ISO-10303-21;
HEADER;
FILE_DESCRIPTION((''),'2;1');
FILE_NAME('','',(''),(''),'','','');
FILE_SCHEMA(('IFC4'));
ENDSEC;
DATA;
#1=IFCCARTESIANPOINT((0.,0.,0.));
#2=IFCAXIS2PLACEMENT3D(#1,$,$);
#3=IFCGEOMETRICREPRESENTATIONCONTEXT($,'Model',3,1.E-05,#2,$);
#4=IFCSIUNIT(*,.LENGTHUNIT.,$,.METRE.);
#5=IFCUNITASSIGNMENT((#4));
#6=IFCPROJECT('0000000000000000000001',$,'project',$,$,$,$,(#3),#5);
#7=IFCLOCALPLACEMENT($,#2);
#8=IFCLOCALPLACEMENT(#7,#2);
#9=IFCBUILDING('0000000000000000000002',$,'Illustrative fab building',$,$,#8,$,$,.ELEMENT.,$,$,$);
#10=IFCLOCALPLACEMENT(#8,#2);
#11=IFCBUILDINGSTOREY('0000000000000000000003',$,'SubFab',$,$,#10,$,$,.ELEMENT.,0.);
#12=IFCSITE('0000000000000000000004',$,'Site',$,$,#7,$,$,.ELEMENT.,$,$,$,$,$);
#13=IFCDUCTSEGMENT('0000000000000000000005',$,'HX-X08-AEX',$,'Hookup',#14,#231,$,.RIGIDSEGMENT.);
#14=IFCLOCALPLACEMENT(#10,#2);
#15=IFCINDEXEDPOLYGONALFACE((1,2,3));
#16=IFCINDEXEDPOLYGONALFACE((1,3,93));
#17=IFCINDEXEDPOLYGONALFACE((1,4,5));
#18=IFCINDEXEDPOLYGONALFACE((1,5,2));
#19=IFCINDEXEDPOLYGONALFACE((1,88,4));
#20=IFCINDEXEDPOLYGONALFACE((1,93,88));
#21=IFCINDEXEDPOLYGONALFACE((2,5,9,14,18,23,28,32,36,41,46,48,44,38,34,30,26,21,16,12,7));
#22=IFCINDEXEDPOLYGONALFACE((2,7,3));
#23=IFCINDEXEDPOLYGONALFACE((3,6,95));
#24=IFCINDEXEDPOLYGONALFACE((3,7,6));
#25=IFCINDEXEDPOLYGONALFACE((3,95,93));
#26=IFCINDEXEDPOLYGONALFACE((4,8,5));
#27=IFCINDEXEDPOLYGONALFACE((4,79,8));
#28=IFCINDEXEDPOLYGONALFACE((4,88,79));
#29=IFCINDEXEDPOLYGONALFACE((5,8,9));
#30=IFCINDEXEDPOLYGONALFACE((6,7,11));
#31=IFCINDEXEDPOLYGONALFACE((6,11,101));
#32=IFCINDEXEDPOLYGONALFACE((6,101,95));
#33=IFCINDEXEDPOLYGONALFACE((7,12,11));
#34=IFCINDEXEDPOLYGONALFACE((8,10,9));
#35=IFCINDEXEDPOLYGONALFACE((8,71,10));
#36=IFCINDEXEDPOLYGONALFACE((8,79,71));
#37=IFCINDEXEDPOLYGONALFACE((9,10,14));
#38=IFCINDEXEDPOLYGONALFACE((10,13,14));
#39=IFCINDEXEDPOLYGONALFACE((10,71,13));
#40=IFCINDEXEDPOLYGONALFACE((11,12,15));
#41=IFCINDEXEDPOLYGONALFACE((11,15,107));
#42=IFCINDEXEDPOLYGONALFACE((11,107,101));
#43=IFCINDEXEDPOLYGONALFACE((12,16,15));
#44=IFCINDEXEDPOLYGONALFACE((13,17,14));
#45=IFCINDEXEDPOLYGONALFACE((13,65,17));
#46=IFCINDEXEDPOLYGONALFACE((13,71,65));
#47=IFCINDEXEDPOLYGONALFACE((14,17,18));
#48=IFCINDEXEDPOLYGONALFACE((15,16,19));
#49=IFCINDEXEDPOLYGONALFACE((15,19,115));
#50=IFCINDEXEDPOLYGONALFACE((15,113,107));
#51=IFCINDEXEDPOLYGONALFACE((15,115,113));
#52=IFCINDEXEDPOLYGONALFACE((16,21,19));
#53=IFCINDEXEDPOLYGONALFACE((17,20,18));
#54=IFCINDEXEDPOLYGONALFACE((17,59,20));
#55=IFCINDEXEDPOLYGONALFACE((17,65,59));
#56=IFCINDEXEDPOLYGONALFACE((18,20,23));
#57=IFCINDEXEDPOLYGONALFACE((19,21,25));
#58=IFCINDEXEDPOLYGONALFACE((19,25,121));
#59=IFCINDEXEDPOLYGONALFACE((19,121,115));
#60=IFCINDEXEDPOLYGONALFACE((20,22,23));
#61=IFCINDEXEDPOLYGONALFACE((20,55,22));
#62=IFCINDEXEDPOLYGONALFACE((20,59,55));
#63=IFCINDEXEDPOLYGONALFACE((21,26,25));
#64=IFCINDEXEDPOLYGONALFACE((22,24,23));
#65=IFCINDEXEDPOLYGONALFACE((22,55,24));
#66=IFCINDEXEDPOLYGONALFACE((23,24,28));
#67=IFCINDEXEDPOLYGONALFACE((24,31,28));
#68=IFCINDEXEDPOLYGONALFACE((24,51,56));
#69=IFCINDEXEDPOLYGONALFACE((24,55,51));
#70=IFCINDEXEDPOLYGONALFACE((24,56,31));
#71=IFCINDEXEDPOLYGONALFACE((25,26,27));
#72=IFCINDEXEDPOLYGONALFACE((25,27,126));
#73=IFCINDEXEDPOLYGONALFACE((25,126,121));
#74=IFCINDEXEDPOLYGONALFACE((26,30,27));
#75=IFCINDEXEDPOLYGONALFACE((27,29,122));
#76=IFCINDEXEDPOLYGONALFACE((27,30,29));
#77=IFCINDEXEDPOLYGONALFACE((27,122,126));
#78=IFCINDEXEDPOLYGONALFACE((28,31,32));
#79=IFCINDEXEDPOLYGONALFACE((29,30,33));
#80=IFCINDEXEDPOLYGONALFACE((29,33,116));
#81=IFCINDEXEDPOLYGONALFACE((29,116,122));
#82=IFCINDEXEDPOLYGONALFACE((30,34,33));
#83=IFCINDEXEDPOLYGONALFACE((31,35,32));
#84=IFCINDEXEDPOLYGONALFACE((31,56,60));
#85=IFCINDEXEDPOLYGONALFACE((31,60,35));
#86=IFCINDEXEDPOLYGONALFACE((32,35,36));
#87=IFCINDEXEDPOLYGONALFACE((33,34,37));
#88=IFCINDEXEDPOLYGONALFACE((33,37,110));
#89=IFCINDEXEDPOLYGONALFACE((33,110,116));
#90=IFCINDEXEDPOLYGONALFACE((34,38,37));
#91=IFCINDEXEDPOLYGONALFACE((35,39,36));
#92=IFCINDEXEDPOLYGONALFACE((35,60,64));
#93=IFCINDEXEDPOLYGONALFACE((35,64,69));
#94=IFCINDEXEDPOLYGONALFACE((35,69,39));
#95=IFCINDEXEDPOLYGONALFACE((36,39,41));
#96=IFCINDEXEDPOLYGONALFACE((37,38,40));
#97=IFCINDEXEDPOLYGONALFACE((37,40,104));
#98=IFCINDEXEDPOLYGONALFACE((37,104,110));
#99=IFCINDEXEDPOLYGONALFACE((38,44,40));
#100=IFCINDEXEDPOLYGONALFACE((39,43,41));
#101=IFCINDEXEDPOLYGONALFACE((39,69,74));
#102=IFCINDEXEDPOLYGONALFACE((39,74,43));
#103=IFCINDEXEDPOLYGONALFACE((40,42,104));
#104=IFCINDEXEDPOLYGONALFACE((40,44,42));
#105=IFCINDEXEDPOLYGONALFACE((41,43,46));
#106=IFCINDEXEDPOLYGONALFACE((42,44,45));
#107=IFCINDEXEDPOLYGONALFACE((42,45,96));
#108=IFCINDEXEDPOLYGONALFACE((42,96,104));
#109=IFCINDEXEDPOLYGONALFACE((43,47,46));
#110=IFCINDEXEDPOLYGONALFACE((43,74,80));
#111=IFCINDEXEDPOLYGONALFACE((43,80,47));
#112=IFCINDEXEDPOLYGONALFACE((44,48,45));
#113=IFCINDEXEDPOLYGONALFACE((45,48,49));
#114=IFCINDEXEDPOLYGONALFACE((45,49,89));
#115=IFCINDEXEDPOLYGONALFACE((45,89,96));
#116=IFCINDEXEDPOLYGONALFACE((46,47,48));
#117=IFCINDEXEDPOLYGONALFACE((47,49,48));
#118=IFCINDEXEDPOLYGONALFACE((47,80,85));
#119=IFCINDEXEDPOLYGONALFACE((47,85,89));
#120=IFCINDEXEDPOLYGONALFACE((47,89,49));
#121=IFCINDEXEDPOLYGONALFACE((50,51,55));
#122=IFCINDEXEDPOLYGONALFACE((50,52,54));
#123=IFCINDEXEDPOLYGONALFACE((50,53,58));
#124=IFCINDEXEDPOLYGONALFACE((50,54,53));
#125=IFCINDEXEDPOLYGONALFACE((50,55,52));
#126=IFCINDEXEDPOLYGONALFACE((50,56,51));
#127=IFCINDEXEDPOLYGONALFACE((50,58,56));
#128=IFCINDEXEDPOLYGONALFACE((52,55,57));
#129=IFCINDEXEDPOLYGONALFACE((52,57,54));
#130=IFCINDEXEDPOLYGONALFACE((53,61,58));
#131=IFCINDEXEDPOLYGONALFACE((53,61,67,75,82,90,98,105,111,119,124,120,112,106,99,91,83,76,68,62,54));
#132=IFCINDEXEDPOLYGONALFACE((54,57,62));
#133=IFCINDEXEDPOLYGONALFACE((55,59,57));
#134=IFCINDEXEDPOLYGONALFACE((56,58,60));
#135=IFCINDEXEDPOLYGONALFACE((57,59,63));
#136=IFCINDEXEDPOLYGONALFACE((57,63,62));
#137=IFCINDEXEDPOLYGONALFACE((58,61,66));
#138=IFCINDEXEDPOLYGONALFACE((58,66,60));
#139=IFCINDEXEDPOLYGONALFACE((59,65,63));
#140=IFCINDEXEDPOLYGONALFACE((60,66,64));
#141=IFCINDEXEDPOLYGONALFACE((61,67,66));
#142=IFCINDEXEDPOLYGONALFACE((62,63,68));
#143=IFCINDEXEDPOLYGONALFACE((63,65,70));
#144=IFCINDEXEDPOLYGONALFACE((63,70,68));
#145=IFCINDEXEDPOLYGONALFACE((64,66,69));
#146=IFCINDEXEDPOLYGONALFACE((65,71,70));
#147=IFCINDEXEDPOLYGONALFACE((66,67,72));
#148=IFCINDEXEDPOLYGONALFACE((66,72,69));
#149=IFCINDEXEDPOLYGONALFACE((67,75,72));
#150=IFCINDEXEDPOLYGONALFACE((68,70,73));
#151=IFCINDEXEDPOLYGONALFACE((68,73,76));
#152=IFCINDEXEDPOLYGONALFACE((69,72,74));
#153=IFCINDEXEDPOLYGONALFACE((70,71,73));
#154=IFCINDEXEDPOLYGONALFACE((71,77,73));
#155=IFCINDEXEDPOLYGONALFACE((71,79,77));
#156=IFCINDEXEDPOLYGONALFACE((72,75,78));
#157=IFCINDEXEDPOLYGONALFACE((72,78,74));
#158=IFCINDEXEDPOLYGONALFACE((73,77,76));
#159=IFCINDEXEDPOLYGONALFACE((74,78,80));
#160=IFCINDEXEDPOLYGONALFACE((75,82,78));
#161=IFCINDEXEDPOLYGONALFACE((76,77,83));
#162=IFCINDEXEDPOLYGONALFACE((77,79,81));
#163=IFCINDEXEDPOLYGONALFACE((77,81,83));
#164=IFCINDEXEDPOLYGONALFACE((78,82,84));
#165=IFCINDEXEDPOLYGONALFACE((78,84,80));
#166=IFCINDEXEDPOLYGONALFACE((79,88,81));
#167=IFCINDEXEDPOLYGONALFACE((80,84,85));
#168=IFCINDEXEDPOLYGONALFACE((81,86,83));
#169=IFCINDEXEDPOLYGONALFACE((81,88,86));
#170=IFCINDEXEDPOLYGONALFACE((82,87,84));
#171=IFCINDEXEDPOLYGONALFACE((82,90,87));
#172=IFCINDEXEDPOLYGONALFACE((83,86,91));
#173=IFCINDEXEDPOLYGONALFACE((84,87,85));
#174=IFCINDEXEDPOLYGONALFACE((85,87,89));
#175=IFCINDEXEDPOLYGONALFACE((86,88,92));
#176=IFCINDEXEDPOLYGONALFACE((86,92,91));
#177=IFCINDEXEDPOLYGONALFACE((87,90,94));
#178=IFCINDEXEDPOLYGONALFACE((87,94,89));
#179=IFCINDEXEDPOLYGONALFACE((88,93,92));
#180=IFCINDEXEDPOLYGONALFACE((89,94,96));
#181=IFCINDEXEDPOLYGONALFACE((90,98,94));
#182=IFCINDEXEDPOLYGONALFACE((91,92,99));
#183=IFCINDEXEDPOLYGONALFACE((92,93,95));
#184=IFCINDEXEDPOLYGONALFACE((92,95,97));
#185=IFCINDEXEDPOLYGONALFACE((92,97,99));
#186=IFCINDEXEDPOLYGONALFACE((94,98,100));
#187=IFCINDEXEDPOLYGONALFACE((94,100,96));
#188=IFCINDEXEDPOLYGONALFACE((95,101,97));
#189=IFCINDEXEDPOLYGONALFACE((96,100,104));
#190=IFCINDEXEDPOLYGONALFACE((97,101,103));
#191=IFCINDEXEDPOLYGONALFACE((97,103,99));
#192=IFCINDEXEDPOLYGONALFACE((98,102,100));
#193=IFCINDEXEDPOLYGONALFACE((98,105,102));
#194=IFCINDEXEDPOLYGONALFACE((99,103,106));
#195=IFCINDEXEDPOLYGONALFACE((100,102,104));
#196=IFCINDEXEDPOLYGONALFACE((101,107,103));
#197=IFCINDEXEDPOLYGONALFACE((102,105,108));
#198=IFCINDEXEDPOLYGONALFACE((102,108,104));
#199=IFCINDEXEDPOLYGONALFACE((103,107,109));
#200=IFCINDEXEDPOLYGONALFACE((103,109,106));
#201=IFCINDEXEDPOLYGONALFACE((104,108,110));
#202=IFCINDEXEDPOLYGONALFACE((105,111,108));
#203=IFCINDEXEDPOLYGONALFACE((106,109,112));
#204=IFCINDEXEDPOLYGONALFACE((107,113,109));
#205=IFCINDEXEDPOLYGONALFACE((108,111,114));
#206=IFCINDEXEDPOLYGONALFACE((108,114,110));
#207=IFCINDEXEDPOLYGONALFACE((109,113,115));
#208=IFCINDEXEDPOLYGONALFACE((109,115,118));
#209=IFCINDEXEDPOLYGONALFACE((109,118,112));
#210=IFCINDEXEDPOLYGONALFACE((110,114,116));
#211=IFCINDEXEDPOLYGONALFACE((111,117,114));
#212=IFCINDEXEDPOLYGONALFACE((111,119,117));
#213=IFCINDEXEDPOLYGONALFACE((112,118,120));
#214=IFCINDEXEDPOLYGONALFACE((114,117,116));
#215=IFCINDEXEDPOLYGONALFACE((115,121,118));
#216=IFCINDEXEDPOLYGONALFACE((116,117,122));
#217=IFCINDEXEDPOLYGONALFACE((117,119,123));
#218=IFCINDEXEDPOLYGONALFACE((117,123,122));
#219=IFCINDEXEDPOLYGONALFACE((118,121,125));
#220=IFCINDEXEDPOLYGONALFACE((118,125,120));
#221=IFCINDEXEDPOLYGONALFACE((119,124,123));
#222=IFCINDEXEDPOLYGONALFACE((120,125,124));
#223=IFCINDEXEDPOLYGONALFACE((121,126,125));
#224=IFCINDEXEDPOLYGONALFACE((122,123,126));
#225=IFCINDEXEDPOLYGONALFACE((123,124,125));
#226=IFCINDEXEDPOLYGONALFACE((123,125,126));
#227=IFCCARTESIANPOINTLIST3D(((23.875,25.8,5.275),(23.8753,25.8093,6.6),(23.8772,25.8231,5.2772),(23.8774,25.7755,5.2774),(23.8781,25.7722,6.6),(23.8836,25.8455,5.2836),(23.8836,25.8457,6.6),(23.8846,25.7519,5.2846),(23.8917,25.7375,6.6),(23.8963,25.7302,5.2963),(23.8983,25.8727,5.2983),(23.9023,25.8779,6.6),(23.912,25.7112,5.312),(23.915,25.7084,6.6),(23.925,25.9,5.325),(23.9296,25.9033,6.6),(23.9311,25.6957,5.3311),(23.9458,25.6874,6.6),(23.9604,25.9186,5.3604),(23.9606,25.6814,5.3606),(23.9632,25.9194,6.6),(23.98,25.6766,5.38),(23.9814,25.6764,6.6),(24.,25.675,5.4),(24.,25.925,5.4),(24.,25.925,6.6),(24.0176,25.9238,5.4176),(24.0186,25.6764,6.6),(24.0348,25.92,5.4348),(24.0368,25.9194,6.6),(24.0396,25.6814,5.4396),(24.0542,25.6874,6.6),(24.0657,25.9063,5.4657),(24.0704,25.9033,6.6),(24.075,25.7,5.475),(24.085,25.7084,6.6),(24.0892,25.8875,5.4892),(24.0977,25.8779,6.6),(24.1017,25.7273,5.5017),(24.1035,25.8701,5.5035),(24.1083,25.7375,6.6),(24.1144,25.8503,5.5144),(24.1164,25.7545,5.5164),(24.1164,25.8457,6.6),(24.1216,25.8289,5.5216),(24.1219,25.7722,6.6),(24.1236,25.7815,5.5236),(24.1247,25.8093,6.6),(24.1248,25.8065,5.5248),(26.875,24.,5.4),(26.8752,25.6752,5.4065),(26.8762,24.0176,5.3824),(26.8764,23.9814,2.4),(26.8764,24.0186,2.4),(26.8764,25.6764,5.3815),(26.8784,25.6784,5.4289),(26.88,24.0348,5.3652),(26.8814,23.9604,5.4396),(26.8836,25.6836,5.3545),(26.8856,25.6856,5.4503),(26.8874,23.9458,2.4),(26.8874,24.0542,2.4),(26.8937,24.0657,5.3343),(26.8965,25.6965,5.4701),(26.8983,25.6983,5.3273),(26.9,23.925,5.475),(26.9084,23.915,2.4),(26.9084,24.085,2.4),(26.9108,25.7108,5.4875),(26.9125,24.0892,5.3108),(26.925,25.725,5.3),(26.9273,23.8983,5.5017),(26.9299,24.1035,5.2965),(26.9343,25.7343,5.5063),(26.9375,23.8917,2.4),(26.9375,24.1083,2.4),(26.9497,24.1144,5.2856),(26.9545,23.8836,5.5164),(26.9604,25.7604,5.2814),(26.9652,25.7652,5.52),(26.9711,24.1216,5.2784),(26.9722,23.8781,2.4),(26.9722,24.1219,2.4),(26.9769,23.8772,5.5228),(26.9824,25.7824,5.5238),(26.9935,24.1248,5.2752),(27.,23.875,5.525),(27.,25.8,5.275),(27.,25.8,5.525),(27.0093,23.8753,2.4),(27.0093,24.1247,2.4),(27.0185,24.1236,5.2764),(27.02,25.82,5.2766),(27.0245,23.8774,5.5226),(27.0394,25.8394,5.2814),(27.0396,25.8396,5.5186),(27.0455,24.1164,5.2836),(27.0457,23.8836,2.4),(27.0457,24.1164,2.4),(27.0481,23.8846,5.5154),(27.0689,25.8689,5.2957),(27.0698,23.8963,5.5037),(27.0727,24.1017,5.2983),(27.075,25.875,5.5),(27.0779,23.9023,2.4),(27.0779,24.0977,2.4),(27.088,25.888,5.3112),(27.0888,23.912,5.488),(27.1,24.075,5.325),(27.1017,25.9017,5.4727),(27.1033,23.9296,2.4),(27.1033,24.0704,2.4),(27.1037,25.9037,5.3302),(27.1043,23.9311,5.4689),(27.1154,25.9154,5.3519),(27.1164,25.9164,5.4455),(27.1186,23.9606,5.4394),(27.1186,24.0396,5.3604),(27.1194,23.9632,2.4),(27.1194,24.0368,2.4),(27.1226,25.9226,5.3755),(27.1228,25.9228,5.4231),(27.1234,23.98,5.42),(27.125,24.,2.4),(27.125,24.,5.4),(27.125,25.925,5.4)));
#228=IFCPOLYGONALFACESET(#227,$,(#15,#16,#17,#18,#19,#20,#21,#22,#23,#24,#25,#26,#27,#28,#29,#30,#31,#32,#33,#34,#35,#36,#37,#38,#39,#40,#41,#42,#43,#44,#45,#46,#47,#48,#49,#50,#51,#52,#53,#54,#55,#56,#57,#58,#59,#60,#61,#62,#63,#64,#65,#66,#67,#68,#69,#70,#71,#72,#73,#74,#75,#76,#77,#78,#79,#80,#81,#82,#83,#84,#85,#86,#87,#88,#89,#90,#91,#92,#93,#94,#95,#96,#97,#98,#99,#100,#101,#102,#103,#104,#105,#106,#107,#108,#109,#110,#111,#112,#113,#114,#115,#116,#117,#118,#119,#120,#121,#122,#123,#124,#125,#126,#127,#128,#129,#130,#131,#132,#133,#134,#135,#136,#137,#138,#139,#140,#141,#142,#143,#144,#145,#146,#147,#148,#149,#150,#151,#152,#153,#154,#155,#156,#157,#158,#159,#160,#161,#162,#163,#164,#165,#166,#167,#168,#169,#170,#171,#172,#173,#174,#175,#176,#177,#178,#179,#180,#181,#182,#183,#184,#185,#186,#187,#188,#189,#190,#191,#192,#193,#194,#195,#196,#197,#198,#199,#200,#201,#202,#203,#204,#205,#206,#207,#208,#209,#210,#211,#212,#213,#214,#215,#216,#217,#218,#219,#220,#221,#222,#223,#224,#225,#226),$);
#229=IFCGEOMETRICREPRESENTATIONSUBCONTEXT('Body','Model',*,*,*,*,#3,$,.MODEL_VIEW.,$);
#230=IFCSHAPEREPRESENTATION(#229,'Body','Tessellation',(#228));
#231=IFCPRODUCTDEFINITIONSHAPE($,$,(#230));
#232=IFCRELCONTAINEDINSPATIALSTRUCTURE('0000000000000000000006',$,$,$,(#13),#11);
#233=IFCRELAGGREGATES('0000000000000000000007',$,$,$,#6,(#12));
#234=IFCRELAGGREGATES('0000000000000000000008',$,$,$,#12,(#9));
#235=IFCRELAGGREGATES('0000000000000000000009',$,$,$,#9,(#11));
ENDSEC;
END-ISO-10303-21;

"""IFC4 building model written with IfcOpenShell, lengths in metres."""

from ifc_helpers import new_model, entity, si_unit, origin, place, context, subcontext, project, spatial, element, save


model = new_model("IFC4")

# Units and contexts
model_context = context("Model", 3, precision=1e-05, world=origin())
body_context = subcontext(model_context, "Body", "Model", "MODEL_VIEW")
ifc_project = project(units=[si_unit("LENGTHUNIT", "METRE")], contexts=[model_context])

# Site, building, storey
site_placement = place(None, origin())
site = spatial("IfcSite", under=ifc_project, at=site_placement, Name="Site", CompositionType="ELEMENT")
building_placement = place(site_placement, origin())
building = spatial("IfcBuilding", under=site, at=building_placement, Name="Illustrative fab building", CompositionType="ELEMENT")
storey_placement = place(building_placement, origin())
storey = spatial("IfcBuildingStorey", under=building, at=storey_placement, Name="SubFab", CompositionType="ELEMENT", Elevation=0.0)

# Duct segment
duct_segment_1_placement = place(storey_placement, origin())
element("IfcDuctSegment", 1, at=duct_segment_1_placement, inside=storey, Name="HX-X08-AEX", ObjectType="Hookup", PredefinedType="RIGIDSEGMENT", context=body_context, shape_type="AdvancedSweptSolid", body=[
    entity("IfcSweptDiskSolid", entity("IfcPolyline", [entity("IfcCartesianPoint", [27.0, 24.0, 2.4]), entity("IfcCartesianPoint", [27.0, 24.0, 5.4]), entity("IfcCartesianPoint", [27.0, 25.8, 5.4]), entity("IfcCartesianPoint", [24.0, 25.8, 5.4]), entity("IfcCartesianPoint", [24.0, 25.8, 6.6])]), 0.125),
])

save(model, "model.ifc")
